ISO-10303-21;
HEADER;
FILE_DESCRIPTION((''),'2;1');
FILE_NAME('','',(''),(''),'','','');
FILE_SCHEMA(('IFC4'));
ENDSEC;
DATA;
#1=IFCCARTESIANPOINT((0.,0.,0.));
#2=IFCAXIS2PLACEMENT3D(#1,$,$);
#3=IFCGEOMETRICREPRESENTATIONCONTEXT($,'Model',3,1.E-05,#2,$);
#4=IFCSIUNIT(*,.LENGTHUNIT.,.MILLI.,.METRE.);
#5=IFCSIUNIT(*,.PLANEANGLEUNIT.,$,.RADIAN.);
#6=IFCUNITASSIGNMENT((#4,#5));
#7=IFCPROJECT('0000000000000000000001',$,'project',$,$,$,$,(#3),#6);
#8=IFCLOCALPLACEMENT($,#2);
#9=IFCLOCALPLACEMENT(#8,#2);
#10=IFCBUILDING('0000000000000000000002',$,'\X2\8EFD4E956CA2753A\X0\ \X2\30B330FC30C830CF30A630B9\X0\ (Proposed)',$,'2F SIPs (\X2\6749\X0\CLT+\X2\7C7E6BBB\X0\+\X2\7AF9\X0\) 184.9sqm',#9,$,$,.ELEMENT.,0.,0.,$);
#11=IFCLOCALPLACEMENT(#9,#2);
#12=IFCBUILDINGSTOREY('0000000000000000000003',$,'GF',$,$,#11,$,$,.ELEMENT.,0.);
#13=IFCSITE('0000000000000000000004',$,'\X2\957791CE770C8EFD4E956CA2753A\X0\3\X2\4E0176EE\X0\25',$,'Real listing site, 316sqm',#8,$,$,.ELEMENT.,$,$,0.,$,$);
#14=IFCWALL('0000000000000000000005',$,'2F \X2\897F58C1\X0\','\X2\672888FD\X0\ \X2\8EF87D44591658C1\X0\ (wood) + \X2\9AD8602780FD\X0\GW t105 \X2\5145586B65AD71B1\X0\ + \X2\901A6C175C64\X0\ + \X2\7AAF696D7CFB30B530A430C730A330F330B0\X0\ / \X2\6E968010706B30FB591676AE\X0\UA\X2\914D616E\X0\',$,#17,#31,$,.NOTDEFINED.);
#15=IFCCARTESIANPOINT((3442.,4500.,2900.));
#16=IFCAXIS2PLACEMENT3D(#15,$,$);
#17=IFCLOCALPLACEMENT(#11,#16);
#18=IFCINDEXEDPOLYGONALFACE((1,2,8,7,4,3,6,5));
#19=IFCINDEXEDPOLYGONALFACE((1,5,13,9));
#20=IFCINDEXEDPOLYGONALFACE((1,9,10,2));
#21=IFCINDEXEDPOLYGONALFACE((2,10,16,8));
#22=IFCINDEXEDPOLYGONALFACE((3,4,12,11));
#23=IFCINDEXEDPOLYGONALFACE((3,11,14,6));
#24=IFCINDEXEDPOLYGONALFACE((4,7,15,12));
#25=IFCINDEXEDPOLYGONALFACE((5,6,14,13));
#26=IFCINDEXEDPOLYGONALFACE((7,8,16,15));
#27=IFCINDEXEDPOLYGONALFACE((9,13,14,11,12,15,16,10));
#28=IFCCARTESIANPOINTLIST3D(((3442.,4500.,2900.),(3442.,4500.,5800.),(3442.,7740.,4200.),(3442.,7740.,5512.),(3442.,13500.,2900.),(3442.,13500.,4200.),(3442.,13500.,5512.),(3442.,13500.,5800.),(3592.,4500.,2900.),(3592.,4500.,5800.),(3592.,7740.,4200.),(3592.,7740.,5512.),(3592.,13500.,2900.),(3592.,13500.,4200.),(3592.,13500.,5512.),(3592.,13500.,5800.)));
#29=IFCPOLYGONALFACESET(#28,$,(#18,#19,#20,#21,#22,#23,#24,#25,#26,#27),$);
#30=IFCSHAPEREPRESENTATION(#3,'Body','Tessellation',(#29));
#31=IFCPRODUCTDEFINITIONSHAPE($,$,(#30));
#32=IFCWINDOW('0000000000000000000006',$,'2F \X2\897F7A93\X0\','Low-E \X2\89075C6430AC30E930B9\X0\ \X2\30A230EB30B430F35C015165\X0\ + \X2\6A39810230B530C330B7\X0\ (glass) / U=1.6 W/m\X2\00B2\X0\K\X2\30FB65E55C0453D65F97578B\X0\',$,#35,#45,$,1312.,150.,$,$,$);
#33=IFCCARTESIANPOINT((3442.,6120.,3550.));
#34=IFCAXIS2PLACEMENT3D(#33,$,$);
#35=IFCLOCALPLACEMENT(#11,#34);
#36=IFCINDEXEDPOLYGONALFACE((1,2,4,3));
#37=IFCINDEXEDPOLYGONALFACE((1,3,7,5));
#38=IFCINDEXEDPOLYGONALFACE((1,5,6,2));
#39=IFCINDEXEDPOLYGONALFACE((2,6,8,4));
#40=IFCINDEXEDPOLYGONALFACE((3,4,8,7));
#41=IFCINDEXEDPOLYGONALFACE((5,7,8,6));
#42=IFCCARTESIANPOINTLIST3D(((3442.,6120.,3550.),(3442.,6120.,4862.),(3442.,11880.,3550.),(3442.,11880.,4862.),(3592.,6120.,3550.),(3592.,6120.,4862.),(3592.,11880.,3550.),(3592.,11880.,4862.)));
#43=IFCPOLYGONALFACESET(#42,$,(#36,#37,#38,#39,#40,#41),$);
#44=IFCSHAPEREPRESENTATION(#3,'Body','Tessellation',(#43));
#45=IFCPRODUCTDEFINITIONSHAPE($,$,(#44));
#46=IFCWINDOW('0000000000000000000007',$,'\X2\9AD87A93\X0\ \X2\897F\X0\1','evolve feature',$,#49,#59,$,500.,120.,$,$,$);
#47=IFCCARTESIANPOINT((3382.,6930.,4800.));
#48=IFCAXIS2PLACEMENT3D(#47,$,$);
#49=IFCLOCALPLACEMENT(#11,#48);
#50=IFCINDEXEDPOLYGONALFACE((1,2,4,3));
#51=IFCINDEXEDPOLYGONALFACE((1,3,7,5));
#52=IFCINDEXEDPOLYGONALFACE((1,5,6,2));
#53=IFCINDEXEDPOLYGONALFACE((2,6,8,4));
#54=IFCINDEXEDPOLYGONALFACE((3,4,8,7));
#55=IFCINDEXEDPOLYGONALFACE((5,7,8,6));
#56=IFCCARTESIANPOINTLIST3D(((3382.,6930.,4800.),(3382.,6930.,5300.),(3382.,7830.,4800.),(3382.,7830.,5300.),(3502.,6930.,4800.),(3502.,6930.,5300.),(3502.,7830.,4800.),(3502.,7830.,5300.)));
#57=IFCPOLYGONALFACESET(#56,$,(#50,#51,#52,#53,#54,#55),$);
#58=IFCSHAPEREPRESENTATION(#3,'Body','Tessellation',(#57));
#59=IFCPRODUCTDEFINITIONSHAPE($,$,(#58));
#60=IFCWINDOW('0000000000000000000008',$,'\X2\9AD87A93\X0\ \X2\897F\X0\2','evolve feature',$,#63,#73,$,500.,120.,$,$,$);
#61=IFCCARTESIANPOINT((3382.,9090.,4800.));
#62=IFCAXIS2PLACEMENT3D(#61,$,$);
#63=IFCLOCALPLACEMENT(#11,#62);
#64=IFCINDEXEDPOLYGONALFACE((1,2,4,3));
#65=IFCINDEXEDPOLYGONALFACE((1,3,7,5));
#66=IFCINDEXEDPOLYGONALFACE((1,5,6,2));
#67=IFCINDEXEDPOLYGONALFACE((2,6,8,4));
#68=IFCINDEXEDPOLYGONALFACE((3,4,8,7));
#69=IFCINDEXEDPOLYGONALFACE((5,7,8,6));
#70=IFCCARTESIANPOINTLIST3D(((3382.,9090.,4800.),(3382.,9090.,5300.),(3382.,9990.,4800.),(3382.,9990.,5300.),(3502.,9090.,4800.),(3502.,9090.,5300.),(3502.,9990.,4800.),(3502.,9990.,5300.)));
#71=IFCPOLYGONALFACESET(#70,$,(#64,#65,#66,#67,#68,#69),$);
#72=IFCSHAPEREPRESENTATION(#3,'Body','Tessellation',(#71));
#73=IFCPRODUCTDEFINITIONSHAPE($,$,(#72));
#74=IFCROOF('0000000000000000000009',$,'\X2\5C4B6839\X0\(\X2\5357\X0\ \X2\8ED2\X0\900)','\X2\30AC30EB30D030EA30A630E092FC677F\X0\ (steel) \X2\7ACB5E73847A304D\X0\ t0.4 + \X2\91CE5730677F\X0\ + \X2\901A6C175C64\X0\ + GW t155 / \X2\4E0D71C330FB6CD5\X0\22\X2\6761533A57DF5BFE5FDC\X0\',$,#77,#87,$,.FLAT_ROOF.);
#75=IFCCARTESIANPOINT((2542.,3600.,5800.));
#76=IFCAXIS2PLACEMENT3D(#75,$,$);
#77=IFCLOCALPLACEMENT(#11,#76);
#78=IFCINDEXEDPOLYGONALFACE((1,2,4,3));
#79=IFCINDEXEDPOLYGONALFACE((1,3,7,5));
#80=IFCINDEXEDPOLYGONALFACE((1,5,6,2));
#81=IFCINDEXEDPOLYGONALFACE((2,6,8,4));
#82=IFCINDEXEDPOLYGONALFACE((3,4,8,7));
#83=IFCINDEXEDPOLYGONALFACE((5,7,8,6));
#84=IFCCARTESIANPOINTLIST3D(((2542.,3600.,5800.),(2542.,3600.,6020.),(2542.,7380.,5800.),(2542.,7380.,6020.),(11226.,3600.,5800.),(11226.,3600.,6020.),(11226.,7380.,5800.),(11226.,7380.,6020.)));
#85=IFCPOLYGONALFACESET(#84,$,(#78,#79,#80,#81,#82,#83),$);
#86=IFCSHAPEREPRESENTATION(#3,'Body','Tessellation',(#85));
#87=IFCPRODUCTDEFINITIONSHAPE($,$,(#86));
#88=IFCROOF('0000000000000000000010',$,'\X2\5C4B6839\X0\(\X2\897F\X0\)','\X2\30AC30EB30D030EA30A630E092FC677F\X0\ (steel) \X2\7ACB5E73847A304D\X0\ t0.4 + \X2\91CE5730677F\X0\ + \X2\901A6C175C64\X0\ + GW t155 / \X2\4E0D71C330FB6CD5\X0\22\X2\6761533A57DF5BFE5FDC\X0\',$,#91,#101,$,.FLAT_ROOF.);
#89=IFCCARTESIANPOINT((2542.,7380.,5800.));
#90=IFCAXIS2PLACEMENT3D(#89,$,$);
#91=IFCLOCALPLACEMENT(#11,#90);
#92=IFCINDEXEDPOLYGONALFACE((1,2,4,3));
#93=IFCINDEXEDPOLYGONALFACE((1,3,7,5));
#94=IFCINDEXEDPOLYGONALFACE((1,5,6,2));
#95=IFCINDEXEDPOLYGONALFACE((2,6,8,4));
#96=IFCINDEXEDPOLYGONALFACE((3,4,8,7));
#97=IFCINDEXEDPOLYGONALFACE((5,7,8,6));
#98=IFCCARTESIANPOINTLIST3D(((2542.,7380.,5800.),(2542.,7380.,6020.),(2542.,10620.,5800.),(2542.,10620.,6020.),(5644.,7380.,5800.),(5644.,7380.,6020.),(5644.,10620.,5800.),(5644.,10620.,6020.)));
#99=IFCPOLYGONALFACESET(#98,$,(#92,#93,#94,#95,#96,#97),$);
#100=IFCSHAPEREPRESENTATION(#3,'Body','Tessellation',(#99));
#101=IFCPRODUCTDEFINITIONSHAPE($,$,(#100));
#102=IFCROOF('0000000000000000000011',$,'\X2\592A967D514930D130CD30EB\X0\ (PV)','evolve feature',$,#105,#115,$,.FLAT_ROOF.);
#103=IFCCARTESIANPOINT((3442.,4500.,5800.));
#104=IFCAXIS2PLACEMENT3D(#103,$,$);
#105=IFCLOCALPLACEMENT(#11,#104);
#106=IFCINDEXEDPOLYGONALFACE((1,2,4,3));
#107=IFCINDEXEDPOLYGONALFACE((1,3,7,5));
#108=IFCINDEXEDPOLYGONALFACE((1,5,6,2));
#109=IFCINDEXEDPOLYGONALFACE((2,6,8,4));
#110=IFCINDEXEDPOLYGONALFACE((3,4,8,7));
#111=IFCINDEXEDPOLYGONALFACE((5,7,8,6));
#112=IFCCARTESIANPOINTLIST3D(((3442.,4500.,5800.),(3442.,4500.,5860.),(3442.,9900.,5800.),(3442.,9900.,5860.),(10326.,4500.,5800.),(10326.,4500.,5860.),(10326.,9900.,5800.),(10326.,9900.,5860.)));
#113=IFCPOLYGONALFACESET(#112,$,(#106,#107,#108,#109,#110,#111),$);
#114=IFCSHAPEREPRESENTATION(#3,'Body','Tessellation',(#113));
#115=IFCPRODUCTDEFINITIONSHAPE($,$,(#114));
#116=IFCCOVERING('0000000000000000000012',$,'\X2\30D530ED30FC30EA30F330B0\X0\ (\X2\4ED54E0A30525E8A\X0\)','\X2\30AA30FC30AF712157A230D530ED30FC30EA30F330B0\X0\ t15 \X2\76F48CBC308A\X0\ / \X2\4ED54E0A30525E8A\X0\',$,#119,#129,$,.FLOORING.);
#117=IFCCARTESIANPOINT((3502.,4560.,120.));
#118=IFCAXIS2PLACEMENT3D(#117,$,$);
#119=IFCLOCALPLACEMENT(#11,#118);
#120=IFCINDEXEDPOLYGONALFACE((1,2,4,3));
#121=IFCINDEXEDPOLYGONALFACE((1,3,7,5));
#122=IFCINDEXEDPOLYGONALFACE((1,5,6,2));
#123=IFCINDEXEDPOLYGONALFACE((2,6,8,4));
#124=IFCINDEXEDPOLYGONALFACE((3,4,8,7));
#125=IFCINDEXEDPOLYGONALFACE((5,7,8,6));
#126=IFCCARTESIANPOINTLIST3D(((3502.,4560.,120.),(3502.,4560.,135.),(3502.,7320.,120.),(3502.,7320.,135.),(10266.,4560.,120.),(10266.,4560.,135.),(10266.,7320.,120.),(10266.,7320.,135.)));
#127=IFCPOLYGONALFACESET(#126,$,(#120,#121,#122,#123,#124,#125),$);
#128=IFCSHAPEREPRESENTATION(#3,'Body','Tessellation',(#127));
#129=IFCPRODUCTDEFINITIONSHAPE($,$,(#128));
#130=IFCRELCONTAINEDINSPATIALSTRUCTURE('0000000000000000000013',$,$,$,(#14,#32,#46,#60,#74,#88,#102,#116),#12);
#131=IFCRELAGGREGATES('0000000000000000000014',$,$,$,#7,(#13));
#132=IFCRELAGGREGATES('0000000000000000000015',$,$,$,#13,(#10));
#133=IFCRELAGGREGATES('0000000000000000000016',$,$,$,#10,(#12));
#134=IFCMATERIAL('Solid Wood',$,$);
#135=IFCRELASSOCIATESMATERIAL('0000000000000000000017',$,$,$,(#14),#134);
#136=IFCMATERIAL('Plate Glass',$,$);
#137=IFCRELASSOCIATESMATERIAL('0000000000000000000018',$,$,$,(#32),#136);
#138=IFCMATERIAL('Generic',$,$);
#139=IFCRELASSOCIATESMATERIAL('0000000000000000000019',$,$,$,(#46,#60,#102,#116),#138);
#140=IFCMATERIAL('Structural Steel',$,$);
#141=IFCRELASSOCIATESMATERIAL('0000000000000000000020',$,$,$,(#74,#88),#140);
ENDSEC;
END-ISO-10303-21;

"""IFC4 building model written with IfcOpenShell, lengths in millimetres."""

from ifc_helpers import new_model, si_unit, frame, frame_2d, origin, place, context, project, spatial, rectangle, extrude, material, element, fill, save


model = new_model("IFC4")

# Units and contexts
model_context = context("Model", 3, precision=1e-05, world=origin())
ifc_project = project(units=[si_unit("LENGTHUNIT", "METRE", prefix="MILLI"), si_unit("PLANEANGLEUNIT", "RADIAN")], contexts=[model_context])

# Site, building, storey
site_placement = place(None, origin())
site = spatial("IfcSite", under=ifc_project, at=site_placement, Name="長野県軽井沢町3丁目25", ObjectType="Real listing site, 316sqm", CompositionType="ELEMENT", RefElevation=0.0)
building_placement = place(site_placement, origin())
building = spatial("IfcBuilding", under=site, at=building_placement, Name="軽井沢町 コートハウス (Proposed)", ObjectType="2F SIPs (杉CLT+籾殻+竹) 184.9sqm", CompositionType="ELEMENT", ElevationOfRefHeight=0.0, ElevationOfTerrain=0.0)
storey_placement = place(building_placement, origin())
storey = spatial("IfcBuildingStorey", under=building, at=storey_placement, Name="GF", CompositionType="ELEMENT", Elevation=0.0)

# Shared definitions
ifc_material_1 = material(Name="Solid Wood")
ifc_material_2 = material(Name="Generic")

# Shared definitions
ifc_material_3 = material(Name="Plate Glass")

# Wall, openings, windows
wall_1_placement = place(storey_placement, frame((3442.0, 4500.0, 2900.0)))
wall_1 = element("IfcWall", 1, at=wall_1_placement, inside=storey, material=ifc_material_1, Name="2F 西壁", Description="木製 軸組外壁 (wood) + 高性能GW t105 充填断熱 + 通気層 + 窯業系サイディング / 準耐火・外皮UA配慮", PredefinedType="NOTDEFINED", context=model_context, shape_type="SweptSolid", body=[
    extrude(rectangle(XDim=150.0, YDim=9000.0, at=frame_2d((75.0, 4500.0))), frame((3442.0, 4500.0, 2900.0)), (0.0, 0.0, 1.0), 2900.0),
])
opening_1_placement = place(storey_placement, frame((3442.0, 6120.0, 3550.0)))
opening_1 = element("IfcOpeningElement", 2, at=opening_1_placement, cuts=wall_1, PredefinedType="NOTDEFINED", context=model_context, shape_type="SweptSolid", body=[
    extrude(rectangle(XDim=150.0, YDim=5760.0, at=frame_2d((75.0, 2880.0))), frame((3442.0, 6120.0, 3550.0)), (0.0, 0.0, 1.0), 1312.0),
])
opening_2_placement = place(storey_placement, frame((3382.0, 6930.0, 4800.0)))
opening_2 = element("IfcOpeningElement", 3, at=opening_2_placement, cuts=wall_1, PredefinedType="NOTDEFINED", context=model_context, shape_type="SweptSolid", body=[
    extrude(rectangle(XDim=120.0, YDim=900.0, at=frame_2d((60.0, 450.0))), frame((3382.0, 6930.0, 4800.0)), (0.0, 0.0, 1.0), 500.0),
])
opening_3_placement = place(storey_placement, frame((3382.0, 9090.0, 4800.0)))
opening_3 = element("IfcOpeningElement", 4, at=opening_3_placement, cuts=wall_1, PredefinedType="NOTDEFINED", context=model_context, shape_type="SweptSolid", body=[
    extrude(rectangle(XDim=120.0, YDim=900.0, at=frame_2d((60.0, 450.0))), frame((3382.0, 9090.0, 4800.0)), (0.0, 0.0, 1.0), 500.0),
])
window_1_placement = place(storey_placement, frame((3442.0, 6120.0, 3550.0)))
window_1 = element("IfcWindow", 5, at=window_1_placement, inside=storey, material=ifc_material_3, Name="2F 西窓", Description="Low-E 複層ガラス アルゴン封入 + 樹脂サッシ (glass) / U=1.6 W/m²K・日射取得型", OverallHeight=1312.0, OverallWidth=150.0, context=model_context, shape_type="SweptSolid", body=[
    extrude(rectangle(XDim=150.0, YDim=5760.0, at=frame_2d((75.0, 2880.0))), frame((3442.0, 6120.0, 3550.0)), (0.0, 0.0, 1.0), 1312.0),
])
fill(opening_1, window_1)
window_2_placement = place(storey_placement, frame((3382.0, 6930.0, 4800.0)))
window_2 = element("IfcWindow", 6, at=window_2_placement, inside=storey, material=ifc_material_2, Name="高窓 西1", Description="evolve feature", OverallHeight=500.0, OverallWidth=120.0, context=model_context, shape_type="SweptSolid", body=[
    extrude(rectangle(XDim=120.0, YDim=900.0, at=frame_2d((60.0, 450.0))), frame((3382.0, 6930.0, 4800.0)), (0.0, 0.0, 1.0), 500.0),
])
fill(opening_2, window_2)
window_3_placement = place(storey_placement, frame((3382.0, 9090.0, 4800.0)))
window_3 = element("IfcWindow", 7, at=window_3_placement, inside=storey, material=ifc_material_2, Name="高窓 西2", Description="evolve feature", OverallHeight=500.0, OverallWidth=120.0, context=model_context, shape_type="SweptSolid", body=[
    extrude(rectangle(XDim=120.0, YDim=900.0, at=frame_2d((60.0, 450.0))), frame((3382.0, 9090.0, 4800.0)), (0.0, 0.0, 1.0), 500.0),
])
fill(opening_3, window_3)

# Roofs
ifc_material_4 = material(Name="Structural Steel")
roof_1_placement = place(storey_placement, frame((2542.0, 3600.0, 5800.0)))
element("IfcRoof", 8, at=roof_1_placement, inside=storey, material=ifc_material_4, Name="屋根(南 軒900)", Description="ガルバリウム鋼板 (steel) 立平葺き t0.4 + 野地板 + 通気層 + GW t155 / 不燃・法22条区域対応", PredefinedType="FLAT_ROOF", context=model_context, shape_type="SweptSolid", body=[
    extrude(rectangle(XDim=8684.0, YDim=3780.0, at=frame_2d((4342.0, 1890.0))), frame((2542.0, 3600.0, 5800.0)), (0.0, 0.0, 1.0), 220.0),
])
roof_2_placement = place(storey_placement, frame((2542.0, 7380.0, 5800.0)))
element("IfcRoof", 9, at=roof_2_placement, inside=storey, material=ifc_material_4, Name="屋根(西)", Description="ガルバリウム鋼板 (steel) 立平葺き t0.4 + 野地板 + 通気層 + GW t155 / 不燃・法22条区域対応", PredefinedType="FLAT_ROOF", context=model_context, shape_type="SweptSolid", body=[
    extrude(rectangle(XDim=3102.0, YDim=3240.0, at=frame_2d((1551.0, 1620.0))), frame((2542.0, 7380.0, 5800.0)), (0.0, 0.0, 1.0), 220.0),
])
roof_3_placement = place(storey_placement, frame((3442.0, 4500.0, 5800.0)))
element("IfcRoof", 10, at=roof_3_placement, inside=storey, material=ifc_material_2, Name="太陽光パネル (PV)", Description="evolve feature", PredefinedType="FLAT_ROOF", context=model_context, shape_type="SweptSolid", body=[
    extrude(rectangle(XDim=6884.0, YDim=5400.0, at=frame_2d((3442.0, 2700.0))), frame((3442.0, 4500.0, 5800.0)), (0.0, 0.0, 1.0), 60.0),
])

# Covering
covering_placement = place(storey_placement, frame((3502.0, 4560.0, 120.0)))
element("IfcCovering", 11, at=covering_placement, inside=storey, material=ifc_material_2, Name="フローリング (仕上げ床)", Description="オーク無垢フローリング t15 直貼り / 仕上げ床", PredefinedType="FLOORING", context=model_context, shape_type="SweptSolid", body=[
    extrude(rectangle(XDim=6764.0, YDim=2760.0, at=frame_2d((3382.0, 1380.0))), frame((3502.0, 4560.0, 120.0)), (0.0, 0.0, 1.0), 15.0),
])

save(model, "model.ifc")
